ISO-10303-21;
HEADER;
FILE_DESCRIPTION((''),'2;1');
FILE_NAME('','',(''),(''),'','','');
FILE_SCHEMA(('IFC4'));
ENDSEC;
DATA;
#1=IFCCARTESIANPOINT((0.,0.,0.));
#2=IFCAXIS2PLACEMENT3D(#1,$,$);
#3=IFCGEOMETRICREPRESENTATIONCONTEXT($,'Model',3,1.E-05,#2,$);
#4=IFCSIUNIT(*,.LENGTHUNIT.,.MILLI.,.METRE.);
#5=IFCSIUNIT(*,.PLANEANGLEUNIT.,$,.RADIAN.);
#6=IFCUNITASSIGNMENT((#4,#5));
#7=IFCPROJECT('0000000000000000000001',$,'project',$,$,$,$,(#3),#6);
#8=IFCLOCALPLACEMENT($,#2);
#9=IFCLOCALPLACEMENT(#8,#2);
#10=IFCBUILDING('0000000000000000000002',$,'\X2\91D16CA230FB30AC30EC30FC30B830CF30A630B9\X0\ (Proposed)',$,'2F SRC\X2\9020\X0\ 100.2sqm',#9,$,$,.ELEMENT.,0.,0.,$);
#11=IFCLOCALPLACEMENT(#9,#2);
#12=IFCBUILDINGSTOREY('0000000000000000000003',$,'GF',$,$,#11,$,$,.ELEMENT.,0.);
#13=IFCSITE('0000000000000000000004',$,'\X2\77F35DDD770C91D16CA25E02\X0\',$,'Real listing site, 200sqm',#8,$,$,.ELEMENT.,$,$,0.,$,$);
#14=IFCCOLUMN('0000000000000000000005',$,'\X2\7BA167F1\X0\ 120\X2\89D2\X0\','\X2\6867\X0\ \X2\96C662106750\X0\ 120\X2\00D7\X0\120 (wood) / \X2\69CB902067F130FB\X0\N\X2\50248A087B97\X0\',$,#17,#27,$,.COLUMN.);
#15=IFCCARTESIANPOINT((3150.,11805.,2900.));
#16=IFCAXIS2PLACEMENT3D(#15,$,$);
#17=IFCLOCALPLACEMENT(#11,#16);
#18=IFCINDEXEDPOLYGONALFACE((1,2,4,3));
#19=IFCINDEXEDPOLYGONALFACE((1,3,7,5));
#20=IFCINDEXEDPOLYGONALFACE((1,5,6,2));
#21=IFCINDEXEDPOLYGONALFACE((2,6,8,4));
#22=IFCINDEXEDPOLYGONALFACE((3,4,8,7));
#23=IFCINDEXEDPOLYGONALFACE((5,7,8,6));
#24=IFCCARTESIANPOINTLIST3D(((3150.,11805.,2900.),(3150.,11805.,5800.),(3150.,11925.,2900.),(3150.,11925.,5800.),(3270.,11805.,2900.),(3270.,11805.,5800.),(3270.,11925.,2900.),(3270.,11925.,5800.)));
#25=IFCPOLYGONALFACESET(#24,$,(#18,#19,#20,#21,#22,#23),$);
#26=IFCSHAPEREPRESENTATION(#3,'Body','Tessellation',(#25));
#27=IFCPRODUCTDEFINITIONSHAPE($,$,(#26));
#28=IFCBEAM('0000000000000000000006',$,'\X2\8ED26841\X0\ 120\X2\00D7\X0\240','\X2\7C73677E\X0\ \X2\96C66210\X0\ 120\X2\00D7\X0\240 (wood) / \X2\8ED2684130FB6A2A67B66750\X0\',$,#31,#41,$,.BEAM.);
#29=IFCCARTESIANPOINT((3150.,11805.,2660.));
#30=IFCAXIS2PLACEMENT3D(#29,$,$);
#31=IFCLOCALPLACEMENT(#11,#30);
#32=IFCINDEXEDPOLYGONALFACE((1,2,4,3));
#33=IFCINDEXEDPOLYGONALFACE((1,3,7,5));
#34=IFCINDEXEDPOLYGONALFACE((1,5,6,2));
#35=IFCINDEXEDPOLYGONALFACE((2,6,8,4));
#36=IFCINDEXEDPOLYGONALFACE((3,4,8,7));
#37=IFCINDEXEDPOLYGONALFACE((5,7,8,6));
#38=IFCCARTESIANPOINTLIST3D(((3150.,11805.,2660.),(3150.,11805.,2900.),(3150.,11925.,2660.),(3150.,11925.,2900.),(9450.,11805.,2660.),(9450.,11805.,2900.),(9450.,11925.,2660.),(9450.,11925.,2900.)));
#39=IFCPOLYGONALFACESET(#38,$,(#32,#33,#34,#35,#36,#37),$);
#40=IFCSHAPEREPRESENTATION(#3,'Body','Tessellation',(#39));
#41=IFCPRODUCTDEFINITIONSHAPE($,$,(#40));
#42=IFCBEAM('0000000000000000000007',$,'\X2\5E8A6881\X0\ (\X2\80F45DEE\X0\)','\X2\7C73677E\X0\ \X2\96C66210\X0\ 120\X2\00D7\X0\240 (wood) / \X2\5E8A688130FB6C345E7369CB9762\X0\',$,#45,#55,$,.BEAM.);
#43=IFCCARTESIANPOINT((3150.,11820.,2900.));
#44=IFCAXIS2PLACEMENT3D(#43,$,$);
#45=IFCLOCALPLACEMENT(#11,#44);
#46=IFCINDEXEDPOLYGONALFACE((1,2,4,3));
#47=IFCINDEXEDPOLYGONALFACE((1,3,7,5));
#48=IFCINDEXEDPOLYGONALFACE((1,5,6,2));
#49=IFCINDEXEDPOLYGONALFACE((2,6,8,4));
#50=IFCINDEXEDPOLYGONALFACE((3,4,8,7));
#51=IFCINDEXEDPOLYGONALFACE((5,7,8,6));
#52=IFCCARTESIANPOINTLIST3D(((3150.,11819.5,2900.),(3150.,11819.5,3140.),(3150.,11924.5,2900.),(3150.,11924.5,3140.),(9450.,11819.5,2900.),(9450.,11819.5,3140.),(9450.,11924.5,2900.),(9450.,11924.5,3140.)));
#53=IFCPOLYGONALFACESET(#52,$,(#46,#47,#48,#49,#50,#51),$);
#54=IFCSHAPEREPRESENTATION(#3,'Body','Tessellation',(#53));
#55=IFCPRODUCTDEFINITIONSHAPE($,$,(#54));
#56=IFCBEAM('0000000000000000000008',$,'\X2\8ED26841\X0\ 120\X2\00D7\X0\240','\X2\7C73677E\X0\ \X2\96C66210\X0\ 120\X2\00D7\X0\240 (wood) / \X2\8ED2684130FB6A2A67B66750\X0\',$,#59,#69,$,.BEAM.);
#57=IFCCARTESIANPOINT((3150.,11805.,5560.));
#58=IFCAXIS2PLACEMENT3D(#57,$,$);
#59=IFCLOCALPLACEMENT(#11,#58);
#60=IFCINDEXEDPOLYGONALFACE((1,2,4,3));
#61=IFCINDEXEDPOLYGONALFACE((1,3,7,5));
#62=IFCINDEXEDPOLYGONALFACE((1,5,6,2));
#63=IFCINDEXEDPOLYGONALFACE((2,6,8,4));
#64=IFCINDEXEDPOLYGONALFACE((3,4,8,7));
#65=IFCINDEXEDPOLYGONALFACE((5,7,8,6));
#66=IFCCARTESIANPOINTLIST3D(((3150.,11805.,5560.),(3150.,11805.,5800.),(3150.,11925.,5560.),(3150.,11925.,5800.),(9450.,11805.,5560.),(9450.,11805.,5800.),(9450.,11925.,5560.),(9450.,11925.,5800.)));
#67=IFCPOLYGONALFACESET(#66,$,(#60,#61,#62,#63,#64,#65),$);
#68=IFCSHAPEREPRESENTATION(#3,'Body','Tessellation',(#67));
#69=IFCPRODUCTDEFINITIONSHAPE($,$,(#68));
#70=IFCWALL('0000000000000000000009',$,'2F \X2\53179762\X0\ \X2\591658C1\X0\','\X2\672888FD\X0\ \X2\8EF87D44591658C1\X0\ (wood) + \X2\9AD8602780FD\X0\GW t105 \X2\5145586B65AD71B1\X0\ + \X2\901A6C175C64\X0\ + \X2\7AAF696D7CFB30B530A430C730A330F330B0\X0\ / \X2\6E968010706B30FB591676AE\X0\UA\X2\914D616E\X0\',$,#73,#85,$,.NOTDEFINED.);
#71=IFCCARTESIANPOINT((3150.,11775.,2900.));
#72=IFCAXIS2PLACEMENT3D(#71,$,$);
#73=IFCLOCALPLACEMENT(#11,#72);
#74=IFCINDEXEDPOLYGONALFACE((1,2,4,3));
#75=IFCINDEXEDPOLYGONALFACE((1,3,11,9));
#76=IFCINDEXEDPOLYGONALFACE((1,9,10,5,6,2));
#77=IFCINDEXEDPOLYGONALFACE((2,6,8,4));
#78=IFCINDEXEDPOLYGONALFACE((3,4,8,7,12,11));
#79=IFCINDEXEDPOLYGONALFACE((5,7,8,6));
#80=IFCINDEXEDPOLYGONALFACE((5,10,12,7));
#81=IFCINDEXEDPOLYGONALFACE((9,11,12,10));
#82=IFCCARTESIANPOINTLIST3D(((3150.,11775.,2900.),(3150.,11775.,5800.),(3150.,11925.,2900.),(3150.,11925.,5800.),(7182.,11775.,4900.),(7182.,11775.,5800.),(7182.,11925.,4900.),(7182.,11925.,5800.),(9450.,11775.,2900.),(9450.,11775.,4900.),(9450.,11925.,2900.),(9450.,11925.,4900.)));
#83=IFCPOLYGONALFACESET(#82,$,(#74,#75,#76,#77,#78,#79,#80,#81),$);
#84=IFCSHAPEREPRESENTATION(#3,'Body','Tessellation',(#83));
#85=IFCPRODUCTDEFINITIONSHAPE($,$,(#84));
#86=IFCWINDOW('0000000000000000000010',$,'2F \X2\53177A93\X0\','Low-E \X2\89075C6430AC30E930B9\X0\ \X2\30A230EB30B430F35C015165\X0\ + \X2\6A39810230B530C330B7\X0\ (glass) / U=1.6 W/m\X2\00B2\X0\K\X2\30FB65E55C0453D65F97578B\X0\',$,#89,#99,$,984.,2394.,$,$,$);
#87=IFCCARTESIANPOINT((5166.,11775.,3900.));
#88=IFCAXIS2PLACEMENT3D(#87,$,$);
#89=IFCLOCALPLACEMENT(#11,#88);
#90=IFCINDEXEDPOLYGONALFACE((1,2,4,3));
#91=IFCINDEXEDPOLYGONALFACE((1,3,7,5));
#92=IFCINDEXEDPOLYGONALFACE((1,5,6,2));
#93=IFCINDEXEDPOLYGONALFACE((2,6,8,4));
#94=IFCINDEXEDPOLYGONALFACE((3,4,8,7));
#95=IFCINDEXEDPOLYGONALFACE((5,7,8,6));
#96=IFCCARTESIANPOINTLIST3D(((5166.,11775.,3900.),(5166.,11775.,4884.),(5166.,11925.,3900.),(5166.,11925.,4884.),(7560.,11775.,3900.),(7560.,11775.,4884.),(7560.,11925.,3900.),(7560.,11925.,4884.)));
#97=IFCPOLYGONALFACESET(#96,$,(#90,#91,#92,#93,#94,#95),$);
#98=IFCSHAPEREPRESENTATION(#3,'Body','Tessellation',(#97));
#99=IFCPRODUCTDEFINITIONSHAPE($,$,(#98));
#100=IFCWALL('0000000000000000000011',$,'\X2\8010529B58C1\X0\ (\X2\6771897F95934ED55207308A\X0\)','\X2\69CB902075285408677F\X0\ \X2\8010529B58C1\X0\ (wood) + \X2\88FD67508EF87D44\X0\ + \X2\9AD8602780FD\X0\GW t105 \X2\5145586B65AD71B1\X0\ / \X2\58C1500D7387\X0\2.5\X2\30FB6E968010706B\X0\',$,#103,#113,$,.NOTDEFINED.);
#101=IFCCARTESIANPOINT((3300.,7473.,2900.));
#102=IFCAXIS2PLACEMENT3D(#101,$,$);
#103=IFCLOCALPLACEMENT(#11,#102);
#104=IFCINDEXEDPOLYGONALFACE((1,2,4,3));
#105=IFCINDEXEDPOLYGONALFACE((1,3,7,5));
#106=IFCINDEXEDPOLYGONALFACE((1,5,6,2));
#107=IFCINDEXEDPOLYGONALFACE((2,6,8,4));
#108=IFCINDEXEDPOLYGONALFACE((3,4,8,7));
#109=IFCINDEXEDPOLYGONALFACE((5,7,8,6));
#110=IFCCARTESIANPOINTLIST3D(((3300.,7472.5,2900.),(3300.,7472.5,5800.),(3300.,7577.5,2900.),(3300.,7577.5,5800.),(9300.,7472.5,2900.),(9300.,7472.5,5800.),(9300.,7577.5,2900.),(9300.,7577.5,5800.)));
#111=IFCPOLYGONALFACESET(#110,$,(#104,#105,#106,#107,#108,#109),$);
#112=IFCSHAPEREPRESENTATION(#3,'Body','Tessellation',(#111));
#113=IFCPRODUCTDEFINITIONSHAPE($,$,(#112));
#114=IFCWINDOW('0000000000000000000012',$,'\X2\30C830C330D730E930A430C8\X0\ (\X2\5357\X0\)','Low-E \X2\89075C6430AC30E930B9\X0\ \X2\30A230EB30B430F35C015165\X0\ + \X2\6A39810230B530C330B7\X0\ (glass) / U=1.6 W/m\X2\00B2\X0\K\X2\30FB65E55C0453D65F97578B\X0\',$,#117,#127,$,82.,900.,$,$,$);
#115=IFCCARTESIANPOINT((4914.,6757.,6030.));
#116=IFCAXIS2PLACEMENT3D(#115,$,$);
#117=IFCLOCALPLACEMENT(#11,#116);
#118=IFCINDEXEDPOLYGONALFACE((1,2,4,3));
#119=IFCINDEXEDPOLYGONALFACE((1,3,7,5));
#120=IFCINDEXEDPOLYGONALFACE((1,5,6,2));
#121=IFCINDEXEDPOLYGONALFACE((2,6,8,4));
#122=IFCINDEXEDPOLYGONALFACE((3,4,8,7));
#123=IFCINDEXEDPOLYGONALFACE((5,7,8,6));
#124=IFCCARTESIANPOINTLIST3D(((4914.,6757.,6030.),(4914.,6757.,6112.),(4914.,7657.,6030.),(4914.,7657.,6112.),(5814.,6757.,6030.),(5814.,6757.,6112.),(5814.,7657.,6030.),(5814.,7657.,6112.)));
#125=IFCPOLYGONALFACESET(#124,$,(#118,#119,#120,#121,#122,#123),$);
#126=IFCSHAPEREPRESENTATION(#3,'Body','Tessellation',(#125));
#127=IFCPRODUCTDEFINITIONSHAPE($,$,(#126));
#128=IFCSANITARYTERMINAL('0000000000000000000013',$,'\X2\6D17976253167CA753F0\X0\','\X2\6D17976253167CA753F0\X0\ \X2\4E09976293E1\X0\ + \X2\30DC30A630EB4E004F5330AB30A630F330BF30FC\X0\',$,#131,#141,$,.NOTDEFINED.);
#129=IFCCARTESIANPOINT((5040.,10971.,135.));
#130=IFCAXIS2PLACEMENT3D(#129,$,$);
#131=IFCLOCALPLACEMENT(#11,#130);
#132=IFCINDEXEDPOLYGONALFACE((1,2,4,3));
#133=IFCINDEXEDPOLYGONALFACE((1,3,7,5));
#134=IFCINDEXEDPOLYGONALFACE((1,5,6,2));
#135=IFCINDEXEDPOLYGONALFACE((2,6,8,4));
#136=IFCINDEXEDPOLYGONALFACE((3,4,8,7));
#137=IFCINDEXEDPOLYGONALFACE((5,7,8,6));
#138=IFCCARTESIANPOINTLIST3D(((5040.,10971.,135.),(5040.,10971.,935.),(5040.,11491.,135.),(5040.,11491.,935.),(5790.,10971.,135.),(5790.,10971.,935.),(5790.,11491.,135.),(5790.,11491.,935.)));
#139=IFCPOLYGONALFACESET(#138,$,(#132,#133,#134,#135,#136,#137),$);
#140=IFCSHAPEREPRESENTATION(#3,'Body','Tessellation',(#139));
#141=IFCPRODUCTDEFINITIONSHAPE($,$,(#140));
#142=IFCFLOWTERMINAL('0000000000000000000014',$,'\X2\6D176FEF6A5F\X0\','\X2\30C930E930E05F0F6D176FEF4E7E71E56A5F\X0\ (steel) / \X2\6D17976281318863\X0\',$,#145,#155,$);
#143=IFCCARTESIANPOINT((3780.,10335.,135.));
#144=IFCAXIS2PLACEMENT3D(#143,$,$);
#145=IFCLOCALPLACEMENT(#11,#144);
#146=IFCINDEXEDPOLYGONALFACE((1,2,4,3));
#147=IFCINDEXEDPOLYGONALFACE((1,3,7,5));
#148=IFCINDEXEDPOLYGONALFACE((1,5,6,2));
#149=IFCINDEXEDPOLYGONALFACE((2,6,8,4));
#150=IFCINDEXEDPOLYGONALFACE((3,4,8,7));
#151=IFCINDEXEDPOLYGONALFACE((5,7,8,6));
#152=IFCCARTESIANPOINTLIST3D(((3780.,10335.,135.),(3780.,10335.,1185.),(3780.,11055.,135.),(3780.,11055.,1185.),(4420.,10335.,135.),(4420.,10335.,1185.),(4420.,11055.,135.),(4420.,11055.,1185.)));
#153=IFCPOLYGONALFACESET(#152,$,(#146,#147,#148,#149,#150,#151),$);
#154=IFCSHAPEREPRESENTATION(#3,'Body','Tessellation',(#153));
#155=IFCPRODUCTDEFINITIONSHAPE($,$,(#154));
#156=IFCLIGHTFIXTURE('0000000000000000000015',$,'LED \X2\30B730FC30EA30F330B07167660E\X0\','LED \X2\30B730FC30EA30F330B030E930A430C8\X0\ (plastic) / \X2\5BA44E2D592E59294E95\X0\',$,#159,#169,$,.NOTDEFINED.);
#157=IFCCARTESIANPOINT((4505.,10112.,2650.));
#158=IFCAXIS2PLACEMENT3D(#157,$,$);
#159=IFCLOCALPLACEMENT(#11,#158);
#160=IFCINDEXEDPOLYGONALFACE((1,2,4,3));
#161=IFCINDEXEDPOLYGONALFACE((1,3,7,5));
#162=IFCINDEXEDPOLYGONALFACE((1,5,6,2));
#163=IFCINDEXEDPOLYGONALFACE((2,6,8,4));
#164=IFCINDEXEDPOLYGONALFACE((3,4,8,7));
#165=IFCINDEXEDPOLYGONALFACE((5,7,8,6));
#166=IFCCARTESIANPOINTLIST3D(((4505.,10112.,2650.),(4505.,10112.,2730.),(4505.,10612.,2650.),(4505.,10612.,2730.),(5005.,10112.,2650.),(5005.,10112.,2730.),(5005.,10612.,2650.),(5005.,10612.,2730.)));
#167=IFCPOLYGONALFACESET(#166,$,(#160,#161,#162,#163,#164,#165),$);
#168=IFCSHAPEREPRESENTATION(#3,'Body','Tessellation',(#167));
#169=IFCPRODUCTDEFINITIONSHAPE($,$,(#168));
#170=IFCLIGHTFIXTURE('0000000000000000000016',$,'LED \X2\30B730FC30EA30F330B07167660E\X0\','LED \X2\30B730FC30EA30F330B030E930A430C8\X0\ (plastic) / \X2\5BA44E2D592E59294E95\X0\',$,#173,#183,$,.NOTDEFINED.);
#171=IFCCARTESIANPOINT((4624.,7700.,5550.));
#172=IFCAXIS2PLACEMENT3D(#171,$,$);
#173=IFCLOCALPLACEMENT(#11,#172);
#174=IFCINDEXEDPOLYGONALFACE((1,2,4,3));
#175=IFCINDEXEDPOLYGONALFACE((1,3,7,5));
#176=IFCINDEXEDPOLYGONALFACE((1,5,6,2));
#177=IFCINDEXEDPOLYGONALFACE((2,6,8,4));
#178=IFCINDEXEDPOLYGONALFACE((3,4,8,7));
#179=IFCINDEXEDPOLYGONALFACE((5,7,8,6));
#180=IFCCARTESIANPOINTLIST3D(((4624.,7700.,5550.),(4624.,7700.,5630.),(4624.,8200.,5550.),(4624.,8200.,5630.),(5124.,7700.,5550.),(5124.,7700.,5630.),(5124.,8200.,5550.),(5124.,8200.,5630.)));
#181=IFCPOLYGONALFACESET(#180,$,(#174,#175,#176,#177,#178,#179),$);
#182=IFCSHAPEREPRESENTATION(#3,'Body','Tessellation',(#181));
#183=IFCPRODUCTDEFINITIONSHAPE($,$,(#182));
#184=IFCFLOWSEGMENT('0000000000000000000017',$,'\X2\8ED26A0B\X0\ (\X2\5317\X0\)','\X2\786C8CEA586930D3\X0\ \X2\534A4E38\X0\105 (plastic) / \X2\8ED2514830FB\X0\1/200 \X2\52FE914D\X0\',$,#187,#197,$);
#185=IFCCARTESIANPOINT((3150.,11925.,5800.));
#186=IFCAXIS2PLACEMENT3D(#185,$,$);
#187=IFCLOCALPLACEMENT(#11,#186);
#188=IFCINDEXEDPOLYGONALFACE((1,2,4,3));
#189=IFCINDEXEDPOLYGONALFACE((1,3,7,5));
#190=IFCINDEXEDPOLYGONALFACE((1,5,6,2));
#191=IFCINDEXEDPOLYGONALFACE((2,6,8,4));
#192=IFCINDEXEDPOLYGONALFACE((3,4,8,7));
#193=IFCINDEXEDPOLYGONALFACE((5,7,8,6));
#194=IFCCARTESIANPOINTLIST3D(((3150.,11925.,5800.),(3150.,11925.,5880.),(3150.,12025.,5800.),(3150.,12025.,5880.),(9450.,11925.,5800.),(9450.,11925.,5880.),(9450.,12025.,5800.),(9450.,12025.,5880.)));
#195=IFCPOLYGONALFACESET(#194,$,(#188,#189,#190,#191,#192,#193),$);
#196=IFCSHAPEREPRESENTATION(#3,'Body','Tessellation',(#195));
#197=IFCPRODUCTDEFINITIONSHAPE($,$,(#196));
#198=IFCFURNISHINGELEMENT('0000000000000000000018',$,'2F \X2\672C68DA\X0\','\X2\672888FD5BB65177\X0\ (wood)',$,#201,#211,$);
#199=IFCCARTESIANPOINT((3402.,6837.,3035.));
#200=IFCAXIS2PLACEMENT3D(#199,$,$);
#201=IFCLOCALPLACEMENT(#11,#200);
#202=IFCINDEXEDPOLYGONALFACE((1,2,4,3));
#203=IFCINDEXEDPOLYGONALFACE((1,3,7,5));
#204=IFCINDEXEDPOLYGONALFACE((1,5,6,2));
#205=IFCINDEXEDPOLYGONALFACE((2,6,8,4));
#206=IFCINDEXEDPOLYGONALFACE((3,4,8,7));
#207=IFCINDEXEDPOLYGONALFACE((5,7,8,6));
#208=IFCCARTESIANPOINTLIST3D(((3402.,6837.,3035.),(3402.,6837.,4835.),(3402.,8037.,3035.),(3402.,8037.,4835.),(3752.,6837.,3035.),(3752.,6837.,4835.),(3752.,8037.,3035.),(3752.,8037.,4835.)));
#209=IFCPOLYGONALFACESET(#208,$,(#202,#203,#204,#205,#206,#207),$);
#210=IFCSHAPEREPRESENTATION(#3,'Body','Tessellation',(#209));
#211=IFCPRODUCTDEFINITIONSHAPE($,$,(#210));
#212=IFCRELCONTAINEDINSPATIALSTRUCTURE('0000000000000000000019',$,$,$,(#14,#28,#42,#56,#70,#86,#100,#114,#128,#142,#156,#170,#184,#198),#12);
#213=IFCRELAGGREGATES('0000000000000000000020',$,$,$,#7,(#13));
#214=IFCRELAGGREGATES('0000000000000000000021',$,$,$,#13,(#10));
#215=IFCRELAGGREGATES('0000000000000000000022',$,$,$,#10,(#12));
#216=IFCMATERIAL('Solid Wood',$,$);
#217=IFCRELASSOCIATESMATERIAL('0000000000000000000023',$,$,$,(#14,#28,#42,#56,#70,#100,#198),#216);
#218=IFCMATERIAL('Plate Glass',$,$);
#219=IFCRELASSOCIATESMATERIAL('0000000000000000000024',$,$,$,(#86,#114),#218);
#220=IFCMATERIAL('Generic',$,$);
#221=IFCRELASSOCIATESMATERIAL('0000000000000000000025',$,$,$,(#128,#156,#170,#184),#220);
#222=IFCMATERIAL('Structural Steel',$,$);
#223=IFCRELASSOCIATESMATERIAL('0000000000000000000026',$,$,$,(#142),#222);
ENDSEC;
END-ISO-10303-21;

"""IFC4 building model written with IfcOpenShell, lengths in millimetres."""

from ifc_helpers import new_model, si_unit, frame, frame_2d, origin, place, context, project, spatial, rectangle, extrude, material, element, fill, save


model = new_model("IFC4")

# Units and contexts
model_context = context("Model", 3, precision=1e-05, world=origin())
ifc_project = project(units=[si_unit("LENGTHUNIT", "METRE", prefix="MILLI"), si_unit("PLANEANGLEUNIT", "RADIAN")], contexts=[model_context])

# Site, building, storey
site_placement = place(None, origin())
site = spatial("IfcSite", under=ifc_project, at=site_placement, Name="石川県金沢市", ObjectType="Real listing site, 200sqm", CompositionType="ELEMENT", RefElevation=0.0)
building_placement = place(site_placement, origin())
building = spatial("IfcBuilding", under=site, at=building_placement, Name="金沢・ガレージハウス (Proposed)", ObjectType="2F SRC造 100.2sqm", CompositionType="ELEMENT", ElevationOfRefHeight=0.0, ElevationOfTerrain=0.0)
storey_placement = place(building_placement, origin())
storey = spatial("IfcBuildingStorey", under=building, at=storey_placement, Name="GF", CompositionType="ELEMENT", Elevation=0.0)

# Column
ifc_material_1 = material(Name="Solid Wood")
column_1_placement = place(storey_placement, frame((3150.0, 11805.0, 2900.0)))
element("IfcColumn", 1, at=column_1_placement, inside=storey, material=ifc_material_1, Name="管柱 120角", Description="桧 集成材 120×120 (wood) / 構造柱・N値計算", PredefinedType="COLUMN", context=model_context, shape_type="SweptSolid", body=[
    extrude(rectangle(XDim=120.0, YDim=120.0, at=frame_2d((60.0, 60.0))), frame((3150.0, 11805.0, 2900.0)), (0.0, 0.0, 1.0), 2900.0),
])

# Beams
beam_1_placement = place(storey_placement, frame((3150.0, 11805.0, 2660.0)))
element("IfcBeam", 2, at=beam_1_placement, inside=storey, material=ifc_material_1, Name="軒桁 120×240", Description="米松 集成 120×240 (wood) / 軒桁・横架材", PredefinedType="BEAM", context=model_context, shape_type="SweptSolid", body=[
    extrude(rectangle(XDim=6300.0, YDim=120.0, at=frame_2d((3150.0, 60.0))), frame((3150.0, 11805.0, 2660.0)), (0.0, 0.0, 1.0), 240.0),
])
beam_2_placement = place(storey_placement, frame((3150.0, 11820.0, 2900.0)))
element("IfcBeam", 3, at=beam_2_placement, inside=storey, material=ifc_material_1, Name="床梁 (胴差)", Description="米松 集成 120×240 (wood) / 床梁・水平構面", PredefinedType="BEAM", context=model_context, shape_type="SweptSolid", body=[
    extrude(rectangle(XDim=6300.0, YDim=105.0, at=frame_2d((3150.0, 52.0))), frame((3150.0, 11820.0, 2900.0)), (0.0, 0.0, 1.0), 240.0),
])
beam_3_placement = place(storey_placement, frame((3150.0, 11805.0, 5560.0)))
element("IfcBeam", 4, at=beam_3_placement, inside=storey, material=ifc_material_1, Name="軒桁 120×240", Description="米松 集成 120×240 (wood) / 軒桁・横架材", PredefinedType="BEAM", context=model_context, shape_type="SweptSolid", body=[
    extrude(rectangle(XDim=6300.0, YDim=120.0, at=frame_2d((3150.0, 60.0))), frame((3150.0, 11805.0, 5560.0)), (0.0, 0.0, 1.0), 240.0),
])

# Wall, opening, window
wall_1_placement = place(storey_placement, frame((3150.0, 11775.0, 2900.0)))
wall_1 = element("IfcWall", 5, at=wall_1_placement, inside=storey, material=ifc_material_1, Name="2F 北面 外壁", Description="木製 軸組外壁 (wood) + 高性能GW t105 充填断熱 + 通気層 + 窯業系サイディング / 準耐火・外皮UA配慮", PredefinedType="NOTDEFINED", context=model_context, shape_type="SweptSolid", body=[
    extrude(rectangle(XDim=6300.0, YDim=150.0, at=frame_2d((3150.0, 75.0))), frame((3150.0, 11775.0, 2900.0)), (0.0, 0.0, 1.0), 2900.0),
])
opening_placement = place(storey_placement, frame((5166.0, 11775.0, 3900.0)))
opening = element("IfcOpeningElement", 6, at=opening_placement, cuts=wall_1, PredefinedType="NOTDEFINED", context=model_context, shape_type="SweptSolid", body=[
    extrude(rectangle(XDim=2394.0, YDim=150.0, at=frame_2d((1197.0, 75.0))), frame((5166.0, 11775.0, 3900.0)), (0.0, 0.0, 1.0), 984.0),
])
ifc_material_2 = material(Name="Plate Glass")
window_1_placement = place(storey_placement, frame((5166.0, 11775.0, 3900.0)))
window_1 = element("IfcWindow", 7, at=window_1_placement, inside=storey, material=ifc_material_2, Name="2F 北窓", Description="Low-E 複層ガラス アルゴン封入 + 樹脂サッシ (glass) / U=1.6 W/m²K・日射取得型", OverallHeight=984.0, OverallWidth=2394.0, context=model_context, shape_type="SweptSolid", body=[
    extrude(rectangle(XDim=2394.0, YDim=150.0, at=frame_2d((1197.0, 75.0))), frame((5166.0, 11775.0, 3900.0)), (0.0, 0.0, 1.0), 984.0),
])
fill(opening, window_1)

# Wall
wall_2_placement = place(storey_placement, frame((3300.0, 7473.0, 2900.0)))
element("IfcWall", 8, at=wall_2_placement, inside=storey, material=ifc_material_1, Name="耐力壁 (東西間仕切り)", Description="構造用合板 耐力壁 (wood) + 製材軸組 + 高性能GW t105 充填断熱 / 壁倍率2.5・準耐火", PredefinedType="NOTDEFINED", context=model_context, shape_type="SweptSolid", body=[
    extrude(rectangle(XDim=6000.0, YDim=105.0, at=frame_2d((3000.0, 52.0))), frame((3300.0, 7473.0, 2900.0)), (0.0, 0.0, 1.0), 2900.0),
])

# Window
window_2_placement = place(storey_placement, frame((4914.0, 6757.0, 6030.0)))
element("IfcWindow", 9, at=window_2_placement, inside=storey, material=ifc_material_2, Name="トップライト (南)", Description="Low-E 複層ガラス アルゴン封入 + 樹脂サッシ (glass) / U=1.6 W/m²K・日射取得型", OverallHeight=82.0, OverallWidth=900.0, context=model_context, shape_type="SweptSolid", body=[
    extrude(rectangle(XDim=900.0, YDim=900.0, at=frame_2d((450.0, 450.0))), frame((4914.0, 6757.0, 6030.0)), (0.0, 0.0, 1.0), 82.0),
])

# Sanitary terminal
ifc_material_3 = material(Name="Generic")
sanitary_terminal_placement = place(storey_placement, frame((5040.0, 10971.0, 135.0)))
element("IfcSanitaryTerminal", 10, at=sanitary_terminal_placement, inside=storey, material=ifc_material_3, Name="洗面化粧台", Description="洗面化粧台 三面鏡 + ボウル一体カウンター", PredefinedType="NOTDEFINED", context=model_context, shape_type="SweptSolid", body=[
    extrude(rectangle(XDim=750.0, YDim=520.0, at=frame_2d((375.0, 260.0))), frame((5040.0, 10971.0, 135.0)), (0.0, 0.0, 1.0), 800.0),
])

# Flow terminal
ifc_material_4 = material(Name="Structural Steel")
flow_terminal_placement = place(storey_placement, frame((3780.0, 10335.0, 135.0)))
element("IfcFlowTerminal", 11, at=flow_terminal_placement, inside=storey, material=ifc_material_4, Name="洗濯機", Description="ドラム式洗濯乾燥機 (steel) / 洗面脱衣", context=model_context, shape_type="SweptSolid", body=[
    extrude(rectangle(XDim=640.0, YDim=720.0, at=frame_2d((320.0, 360.0))), frame((3780.0, 10335.0, 135.0)), (0.0, 0.0, 1.0), 1050.0),
])

# Light fixtures
light_fixture_1_placement = place(storey_placement, frame((4505.0, 10112.0, 2650.0)))
element("IfcLightFixture", 12, at=light_fixture_1_placement, inside=storey, material=ifc_material_3, Name="LED シーリング照明", Description="LED シーリングライト (plastic) / 室中央天井", PredefinedType="NOTDEFINED", context=model_context, shape_type="SweptSolid", body=[
    extrude(rectangle(XDim=500.0, YDim=500.0, at=frame_2d((250.0, 250.0))), frame((4505.0, 10112.0, 2650.0)), (0.0, 0.0, 1.0), 80.0),
])
light_fixture_2_placement = place(storey_placement, frame((4624.0, 7700.0, 5550.0)))
element("IfcLightFixture", 13, at=light_fixture_2_placement, inside=storey, material=ifc_material_3, Name="LED シーリング照明", Description="LED シーリングライト (plastic) / 室中央天井", PredefinedType="NOTDEFINED", context=model_context, shape_type="SweptSolid", body=[
    extrude(rectangle(XDim=500.0, YDim=500.0, at=frame_2d((250.0, 250.0))), frame((4624.0, 7700.0, 5550.0)), (0.0, 0.0, 1.0), 80.0),
])

# Flow segment
flow_segment_placement = place(storey_placement, frame((3150.0, 11925.0, 5800.0)))
element("IfcFlowSegment", 14, at=flow_segment_placement, inside=storey, material=ifc_material_3, Name="軒樋 (北)", Description="硬質塩ビ 半丸105 (plastic) / 軒先・1/200 勾配", context=model_context, shape_type="SweptSolid", body=[
    extrude(rectangle(XDim=6300.0, YDim=100.0, at=frame_2d((3150.0, 50.0))), frame((3150.0, 11925.0, 5800.0)), (0.0, 0.0, 1.0), 80.0),
])

# Furnishing element
furnishing_placement = place(storey_placement, frame((3402.0, 6837.0, 3035.0)))
element("IfcFurnishingElement", 15, at=furnishing_placement, inside=storey, material=ifc_material_1, Name="2F 本棚", Description="木製家具 (wood)", context=model_context, shape_type="SweptSolid", body=[
    extrude(rectangle(XDim=350.0, YDim=1200.0, at=frame_2d((175.0, 600.0))), frame((3402.0, 6837.0, 3035.0)), (0.0, 0.0, 1.0), 1800.0),
])

save(model, "model.ifc")
